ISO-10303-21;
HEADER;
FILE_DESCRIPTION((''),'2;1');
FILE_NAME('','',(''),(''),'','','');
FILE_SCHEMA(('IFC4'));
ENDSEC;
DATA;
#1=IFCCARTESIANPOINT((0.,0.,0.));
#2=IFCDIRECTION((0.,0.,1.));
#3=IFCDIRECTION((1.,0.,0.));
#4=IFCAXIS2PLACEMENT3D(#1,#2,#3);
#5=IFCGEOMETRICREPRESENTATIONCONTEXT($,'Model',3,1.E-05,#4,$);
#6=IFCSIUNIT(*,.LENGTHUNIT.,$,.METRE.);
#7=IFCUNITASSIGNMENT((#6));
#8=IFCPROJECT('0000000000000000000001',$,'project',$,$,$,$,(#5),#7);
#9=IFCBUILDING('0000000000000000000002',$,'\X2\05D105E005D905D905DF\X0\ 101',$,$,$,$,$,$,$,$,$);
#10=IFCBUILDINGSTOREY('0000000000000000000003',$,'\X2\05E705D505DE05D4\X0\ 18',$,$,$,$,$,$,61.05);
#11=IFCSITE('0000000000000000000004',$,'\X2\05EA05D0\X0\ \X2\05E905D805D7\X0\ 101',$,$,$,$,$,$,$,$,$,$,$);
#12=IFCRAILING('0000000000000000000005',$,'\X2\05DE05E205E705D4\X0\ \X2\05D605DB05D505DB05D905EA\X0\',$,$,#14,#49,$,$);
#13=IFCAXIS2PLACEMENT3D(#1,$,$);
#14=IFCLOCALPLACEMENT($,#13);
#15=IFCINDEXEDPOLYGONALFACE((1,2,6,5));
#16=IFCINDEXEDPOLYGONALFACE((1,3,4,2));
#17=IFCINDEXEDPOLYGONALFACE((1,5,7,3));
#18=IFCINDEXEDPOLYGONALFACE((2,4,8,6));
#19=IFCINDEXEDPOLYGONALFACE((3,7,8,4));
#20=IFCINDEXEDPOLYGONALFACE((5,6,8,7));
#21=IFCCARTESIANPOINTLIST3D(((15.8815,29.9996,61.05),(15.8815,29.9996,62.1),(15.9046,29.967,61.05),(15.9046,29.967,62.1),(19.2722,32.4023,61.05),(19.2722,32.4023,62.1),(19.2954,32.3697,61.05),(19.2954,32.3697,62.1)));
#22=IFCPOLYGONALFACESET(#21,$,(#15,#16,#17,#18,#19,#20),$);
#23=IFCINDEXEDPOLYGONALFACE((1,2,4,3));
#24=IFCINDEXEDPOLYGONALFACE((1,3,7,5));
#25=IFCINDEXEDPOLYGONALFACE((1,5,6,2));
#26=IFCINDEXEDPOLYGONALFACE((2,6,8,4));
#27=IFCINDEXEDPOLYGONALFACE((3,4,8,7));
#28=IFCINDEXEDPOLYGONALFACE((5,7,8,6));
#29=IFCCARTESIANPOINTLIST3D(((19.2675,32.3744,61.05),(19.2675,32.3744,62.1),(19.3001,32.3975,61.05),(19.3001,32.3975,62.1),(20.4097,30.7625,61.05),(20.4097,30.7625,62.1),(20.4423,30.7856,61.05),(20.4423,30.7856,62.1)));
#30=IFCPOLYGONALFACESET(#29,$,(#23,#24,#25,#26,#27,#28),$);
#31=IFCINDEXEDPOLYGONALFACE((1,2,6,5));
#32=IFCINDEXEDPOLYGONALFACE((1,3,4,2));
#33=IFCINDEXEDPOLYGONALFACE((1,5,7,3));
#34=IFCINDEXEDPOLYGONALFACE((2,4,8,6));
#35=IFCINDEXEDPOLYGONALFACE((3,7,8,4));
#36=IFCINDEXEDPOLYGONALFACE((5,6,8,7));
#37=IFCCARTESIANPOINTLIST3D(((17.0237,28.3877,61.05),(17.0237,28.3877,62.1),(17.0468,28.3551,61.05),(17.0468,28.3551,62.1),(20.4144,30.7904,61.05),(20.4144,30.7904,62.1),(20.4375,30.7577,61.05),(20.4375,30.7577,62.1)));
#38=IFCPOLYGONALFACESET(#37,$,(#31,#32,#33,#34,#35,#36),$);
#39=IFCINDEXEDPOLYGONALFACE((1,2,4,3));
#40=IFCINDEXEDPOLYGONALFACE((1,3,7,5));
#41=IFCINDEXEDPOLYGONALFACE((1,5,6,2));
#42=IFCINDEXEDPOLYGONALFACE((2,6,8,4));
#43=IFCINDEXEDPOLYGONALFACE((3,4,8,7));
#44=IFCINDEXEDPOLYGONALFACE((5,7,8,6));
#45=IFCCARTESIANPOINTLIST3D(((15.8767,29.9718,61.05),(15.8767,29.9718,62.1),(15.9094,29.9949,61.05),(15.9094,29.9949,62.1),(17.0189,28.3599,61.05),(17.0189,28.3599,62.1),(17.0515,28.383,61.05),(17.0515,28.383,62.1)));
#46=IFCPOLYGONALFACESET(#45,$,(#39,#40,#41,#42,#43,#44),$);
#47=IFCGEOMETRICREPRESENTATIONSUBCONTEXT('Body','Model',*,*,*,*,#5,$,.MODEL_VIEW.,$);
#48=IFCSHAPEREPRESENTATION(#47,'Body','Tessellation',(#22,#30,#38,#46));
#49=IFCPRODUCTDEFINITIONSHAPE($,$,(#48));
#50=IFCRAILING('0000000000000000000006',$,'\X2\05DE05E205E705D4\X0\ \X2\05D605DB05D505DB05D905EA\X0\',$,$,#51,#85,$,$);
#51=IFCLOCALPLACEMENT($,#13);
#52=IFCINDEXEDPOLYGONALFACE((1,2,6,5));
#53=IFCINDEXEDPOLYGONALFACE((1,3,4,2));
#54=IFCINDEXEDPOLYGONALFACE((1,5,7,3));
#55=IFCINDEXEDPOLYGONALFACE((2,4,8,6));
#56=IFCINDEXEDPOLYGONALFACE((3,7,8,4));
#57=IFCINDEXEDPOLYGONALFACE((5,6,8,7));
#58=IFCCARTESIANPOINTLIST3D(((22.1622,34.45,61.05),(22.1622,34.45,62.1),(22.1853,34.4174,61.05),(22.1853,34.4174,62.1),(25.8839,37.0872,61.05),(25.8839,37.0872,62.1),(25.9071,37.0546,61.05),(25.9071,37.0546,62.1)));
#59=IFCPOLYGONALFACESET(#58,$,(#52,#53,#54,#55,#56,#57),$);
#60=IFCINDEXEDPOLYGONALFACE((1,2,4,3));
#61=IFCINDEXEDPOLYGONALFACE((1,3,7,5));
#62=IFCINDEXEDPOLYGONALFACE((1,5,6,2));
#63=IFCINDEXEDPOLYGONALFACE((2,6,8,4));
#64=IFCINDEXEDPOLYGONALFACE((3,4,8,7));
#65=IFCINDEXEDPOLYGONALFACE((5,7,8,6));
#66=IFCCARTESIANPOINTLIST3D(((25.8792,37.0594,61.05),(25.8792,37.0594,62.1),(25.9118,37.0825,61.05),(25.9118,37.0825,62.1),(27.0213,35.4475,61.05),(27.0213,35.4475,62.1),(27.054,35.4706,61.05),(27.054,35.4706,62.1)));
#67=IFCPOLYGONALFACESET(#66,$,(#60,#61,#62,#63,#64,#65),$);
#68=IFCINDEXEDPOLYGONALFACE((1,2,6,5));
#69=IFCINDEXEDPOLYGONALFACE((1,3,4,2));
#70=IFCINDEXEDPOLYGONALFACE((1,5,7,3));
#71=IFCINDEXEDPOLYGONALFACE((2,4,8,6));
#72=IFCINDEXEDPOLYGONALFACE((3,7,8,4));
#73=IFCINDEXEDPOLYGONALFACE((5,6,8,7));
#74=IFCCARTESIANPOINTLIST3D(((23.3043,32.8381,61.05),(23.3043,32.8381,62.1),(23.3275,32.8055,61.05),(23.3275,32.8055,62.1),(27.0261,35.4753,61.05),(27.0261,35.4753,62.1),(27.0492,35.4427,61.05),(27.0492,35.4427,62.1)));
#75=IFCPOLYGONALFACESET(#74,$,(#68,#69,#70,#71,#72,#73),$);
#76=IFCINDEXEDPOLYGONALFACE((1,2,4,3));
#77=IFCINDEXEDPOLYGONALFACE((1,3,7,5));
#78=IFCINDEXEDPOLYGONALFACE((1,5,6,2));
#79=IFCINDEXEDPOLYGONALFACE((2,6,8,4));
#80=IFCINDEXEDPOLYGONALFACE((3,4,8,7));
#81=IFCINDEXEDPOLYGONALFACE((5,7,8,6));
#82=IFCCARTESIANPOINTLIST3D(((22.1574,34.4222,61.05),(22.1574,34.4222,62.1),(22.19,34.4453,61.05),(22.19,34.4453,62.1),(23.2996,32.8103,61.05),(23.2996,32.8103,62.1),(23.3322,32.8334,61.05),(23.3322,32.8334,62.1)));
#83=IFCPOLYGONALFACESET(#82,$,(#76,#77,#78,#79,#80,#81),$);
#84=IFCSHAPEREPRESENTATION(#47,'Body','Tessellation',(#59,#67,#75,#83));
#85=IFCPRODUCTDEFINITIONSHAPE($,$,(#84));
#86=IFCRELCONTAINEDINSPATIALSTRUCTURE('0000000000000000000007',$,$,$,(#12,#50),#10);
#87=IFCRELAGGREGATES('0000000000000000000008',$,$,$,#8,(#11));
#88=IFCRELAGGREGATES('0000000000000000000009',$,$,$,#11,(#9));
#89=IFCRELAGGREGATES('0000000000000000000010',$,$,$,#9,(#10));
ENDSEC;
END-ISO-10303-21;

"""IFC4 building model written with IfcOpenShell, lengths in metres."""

from ifc_helpers import new_model, si_unit, frame, origin_with_axes, context, subcontext, project, spatial, polyline, outline, extrude, element, save


model = new_model("IFC4")

# Units and contexts
model_context = context("Model", 3, precision=1e-05, world=origin_with_axes())
body_context = subcontext(model_context, "Body", "Model", "MODEL_VIEW")
ifc_project = project(units=[si_unit("LENGTHUNIT", "METRE")], contexts=[model_context])

# Site, building, storey
site = spatial("IfcSite", under=ifc_project, Name="תא שטח 101")
building = spatial("IfcBuilding", under=site, Name="בניין 101")
storey = spatial("IfcBuildingStorey", under=building, Name="קומה 18", Elevation=61.05)

# Railings
element("IfcRailing", 1, inside=storey, Name="מעקה זכוכית", context=body_context, shape_type="SweptSolid", body=[
    extrude(outline(polyline([(15.9046, 29.967), (19.2954, 32.3697), (19.2722, 32.4023), (15.8815, 29.9996), (15.9046, 29.967)])), frame((0.0, 0.0, 61.05)), (0.0, 0.0, 1.0), 1.05),
    extrude(outline(polyline([(19.2675, 32.3744), (20.4097, 30.7625), (20.4423, 30.7856), (19.3001, 32.3975), (19.2675, 32.3744)])), frame((0.0, 0.0, 61.05)), (0.0, 0.0, 1.0), 1.05),
    extrude(outline(polyline([(20.4144, 30.7904), (17.0237, 28.3877), (17.0468, 28.3551), (20.4375, 30.7577), (20.4144, 30.7904)])), frame((0.0, 0.0, 61.05)), (0.0, 0.0, 1.0), 1.05),
    extrude(outline(polyline([(17.0515, 28.383), (15.9094, 29.9949), (15.8767, 29.9718), (17.0189, 28.3599), (17.0515, 28.383)])), frame((0.0, 0.0, 61.05)), (0.0, 0.0, 1.0), 1.05),
])
element("IfcRailing", 2, inside=storey, Name="מעקה זכוכית", context=body_context, shape_type="SweptSolid", body=[
    extrude(outline(polyline([(22.1853, 34.4174), (25.9071, 37.0546), (25.8839, 37.0872), (22.1622, 34.45), (22.1853, 34.4174)])), frame((0.0, 0.0, 61.05)), (0.0, 0.0, 1.0), 1.05),
    extrude(outline(polyline([(25.8792, 37.0594), (27.0213, 35.4475), (27.054, 35.4706), (25.9118, 37.0825), (25.8792, 37.0594)])), frame((0.0, 0.0, 61.05)), (0.0, 0.0, 1.0), 1.05),
    extrude(outline(polyline([(27.0261, 35.4753), (23.3043, 32.8381), (23.3275, 32.8055), (27.0492, 35.4427), (27.0261, 35.4753)])), frame((0.0, 0.0, 61.05)), (0.0, 0.0, 1.0), 1.05),
    extrude(outline(polyline([(23.3322, 32.8334), (22.19, 34.4453), (22.1574, 34.4222), (23.2996, 32.8103), (23.3322, 32.8334)])), frame((0.0, 0.0, 61.05)), (0.0, 0.0, 1.0), 1.05),
])

save(model, "model.ifc")
